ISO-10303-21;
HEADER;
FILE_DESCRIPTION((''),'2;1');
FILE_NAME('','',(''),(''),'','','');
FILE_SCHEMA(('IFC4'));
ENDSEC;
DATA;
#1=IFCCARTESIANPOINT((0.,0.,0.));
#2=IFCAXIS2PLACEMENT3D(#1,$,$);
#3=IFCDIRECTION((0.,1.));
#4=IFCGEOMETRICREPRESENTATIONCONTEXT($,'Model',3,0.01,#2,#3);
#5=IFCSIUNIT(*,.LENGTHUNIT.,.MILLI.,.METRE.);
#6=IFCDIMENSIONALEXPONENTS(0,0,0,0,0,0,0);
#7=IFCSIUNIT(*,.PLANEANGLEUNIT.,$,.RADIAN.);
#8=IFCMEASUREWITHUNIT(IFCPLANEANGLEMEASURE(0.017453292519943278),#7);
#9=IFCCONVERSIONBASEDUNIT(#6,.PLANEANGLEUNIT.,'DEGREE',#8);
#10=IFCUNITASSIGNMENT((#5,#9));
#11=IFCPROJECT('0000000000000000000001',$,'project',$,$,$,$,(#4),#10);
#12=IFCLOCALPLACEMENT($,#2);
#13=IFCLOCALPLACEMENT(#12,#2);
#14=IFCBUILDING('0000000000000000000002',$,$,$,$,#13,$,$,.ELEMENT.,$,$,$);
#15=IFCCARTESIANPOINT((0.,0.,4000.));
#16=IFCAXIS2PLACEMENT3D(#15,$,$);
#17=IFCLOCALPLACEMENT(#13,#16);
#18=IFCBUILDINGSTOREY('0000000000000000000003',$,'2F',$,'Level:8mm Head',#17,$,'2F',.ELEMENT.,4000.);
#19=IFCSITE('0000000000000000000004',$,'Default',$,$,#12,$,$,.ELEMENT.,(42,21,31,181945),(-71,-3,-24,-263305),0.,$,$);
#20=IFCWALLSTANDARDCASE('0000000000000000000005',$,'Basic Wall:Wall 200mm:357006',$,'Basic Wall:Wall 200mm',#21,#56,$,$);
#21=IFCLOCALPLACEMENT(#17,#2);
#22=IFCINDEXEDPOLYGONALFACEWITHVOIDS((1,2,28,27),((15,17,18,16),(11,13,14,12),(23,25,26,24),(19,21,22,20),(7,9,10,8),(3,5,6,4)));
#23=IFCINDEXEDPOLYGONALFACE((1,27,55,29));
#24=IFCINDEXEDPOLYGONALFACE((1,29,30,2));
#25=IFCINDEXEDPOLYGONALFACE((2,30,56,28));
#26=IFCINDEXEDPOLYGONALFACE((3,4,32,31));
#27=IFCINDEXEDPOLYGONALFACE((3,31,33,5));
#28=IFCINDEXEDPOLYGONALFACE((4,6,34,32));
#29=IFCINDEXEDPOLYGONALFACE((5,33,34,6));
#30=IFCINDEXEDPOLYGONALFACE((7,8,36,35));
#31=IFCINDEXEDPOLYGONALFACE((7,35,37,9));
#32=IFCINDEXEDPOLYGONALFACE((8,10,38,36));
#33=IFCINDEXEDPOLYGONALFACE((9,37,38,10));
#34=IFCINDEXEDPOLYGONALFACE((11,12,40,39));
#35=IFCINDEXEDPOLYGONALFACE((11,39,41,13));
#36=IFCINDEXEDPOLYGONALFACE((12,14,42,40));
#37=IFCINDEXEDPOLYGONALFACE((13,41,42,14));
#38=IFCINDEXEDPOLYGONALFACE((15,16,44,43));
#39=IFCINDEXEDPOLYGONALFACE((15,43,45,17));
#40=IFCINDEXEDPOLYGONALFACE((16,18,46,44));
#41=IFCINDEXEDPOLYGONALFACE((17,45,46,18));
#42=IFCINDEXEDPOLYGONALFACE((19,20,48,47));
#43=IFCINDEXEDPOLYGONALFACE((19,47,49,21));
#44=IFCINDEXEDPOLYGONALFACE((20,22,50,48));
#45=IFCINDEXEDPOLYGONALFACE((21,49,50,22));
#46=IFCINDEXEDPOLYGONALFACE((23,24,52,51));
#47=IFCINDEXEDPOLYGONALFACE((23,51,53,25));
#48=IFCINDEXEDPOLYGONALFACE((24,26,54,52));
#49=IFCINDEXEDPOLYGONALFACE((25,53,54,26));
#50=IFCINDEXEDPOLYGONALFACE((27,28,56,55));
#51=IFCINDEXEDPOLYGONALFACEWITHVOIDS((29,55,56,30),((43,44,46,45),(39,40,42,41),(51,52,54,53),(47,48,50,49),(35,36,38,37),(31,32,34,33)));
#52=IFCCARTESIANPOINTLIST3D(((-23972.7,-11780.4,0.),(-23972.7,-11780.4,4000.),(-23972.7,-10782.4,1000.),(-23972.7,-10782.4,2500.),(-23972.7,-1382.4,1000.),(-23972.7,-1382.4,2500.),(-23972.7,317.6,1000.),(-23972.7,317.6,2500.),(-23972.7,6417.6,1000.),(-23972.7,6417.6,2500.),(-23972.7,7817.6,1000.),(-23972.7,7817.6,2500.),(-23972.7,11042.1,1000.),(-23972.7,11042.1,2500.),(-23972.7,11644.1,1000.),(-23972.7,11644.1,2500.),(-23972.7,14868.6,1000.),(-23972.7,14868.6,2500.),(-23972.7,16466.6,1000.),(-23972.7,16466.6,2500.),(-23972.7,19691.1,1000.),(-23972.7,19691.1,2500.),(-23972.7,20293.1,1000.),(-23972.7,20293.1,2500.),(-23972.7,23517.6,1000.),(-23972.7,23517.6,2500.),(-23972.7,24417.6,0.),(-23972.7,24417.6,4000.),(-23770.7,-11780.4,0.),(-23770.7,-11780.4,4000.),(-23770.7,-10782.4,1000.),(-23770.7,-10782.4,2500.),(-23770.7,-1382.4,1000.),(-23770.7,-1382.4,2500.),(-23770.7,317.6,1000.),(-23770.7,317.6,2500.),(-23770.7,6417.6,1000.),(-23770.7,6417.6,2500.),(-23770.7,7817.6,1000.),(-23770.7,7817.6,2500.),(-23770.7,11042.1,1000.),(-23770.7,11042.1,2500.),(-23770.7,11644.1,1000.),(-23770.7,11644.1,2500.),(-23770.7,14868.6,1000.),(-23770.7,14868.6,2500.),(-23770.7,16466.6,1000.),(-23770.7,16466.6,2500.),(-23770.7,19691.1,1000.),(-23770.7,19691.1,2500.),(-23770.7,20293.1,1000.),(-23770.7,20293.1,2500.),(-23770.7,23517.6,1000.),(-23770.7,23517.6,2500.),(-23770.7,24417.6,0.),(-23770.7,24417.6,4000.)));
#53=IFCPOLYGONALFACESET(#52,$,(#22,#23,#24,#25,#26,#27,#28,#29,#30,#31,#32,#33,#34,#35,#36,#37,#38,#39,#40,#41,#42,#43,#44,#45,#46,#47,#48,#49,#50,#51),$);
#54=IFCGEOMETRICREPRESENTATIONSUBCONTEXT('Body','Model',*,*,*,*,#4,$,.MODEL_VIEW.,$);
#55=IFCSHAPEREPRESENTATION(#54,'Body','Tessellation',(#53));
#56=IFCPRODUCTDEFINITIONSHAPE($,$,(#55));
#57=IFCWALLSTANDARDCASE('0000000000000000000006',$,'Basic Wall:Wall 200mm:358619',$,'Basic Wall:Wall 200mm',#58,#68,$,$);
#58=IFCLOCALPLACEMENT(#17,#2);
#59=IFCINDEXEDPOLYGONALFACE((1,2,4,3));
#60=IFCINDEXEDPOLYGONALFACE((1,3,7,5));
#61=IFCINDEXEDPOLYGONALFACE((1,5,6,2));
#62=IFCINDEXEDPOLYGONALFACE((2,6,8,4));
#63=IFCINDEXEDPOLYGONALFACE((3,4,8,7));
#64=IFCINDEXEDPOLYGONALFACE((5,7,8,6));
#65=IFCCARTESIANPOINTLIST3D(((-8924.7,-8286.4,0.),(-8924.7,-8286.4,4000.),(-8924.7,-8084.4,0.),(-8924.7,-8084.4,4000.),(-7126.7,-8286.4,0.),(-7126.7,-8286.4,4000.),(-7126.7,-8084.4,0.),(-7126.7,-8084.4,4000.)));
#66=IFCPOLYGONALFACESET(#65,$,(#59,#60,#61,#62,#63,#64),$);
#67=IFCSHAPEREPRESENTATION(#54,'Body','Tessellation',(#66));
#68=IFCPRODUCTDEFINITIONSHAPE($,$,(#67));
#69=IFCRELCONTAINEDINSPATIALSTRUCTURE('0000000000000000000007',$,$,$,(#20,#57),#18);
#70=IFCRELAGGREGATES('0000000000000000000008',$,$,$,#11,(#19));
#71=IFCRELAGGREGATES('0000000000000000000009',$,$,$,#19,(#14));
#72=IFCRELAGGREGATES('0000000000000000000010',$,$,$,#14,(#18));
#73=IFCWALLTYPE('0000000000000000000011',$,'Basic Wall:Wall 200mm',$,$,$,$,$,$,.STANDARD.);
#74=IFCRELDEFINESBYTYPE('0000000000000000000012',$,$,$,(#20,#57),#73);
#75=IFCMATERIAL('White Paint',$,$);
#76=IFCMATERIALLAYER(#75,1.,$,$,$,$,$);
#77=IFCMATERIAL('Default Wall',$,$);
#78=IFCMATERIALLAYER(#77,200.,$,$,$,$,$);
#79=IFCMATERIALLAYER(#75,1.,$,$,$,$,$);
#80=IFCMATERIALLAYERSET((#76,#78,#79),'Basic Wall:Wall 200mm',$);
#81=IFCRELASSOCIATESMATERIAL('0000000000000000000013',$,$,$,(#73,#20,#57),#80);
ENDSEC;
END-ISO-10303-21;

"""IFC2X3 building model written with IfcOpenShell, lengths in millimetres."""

from ifc_helpers import new_model, entity, si_unit, converted_unit, direction, frame, frame_2d, origin, origin_2d_with_axis, place, context, subcontext, project, spatial, rectangle, extrude, material, layer, layer_set, layer_usage, type_object, element, save


model = new_model("IFC2X3")

# Units and contexts
model_context = context("Model", 3, precision=0.01, world=origin(), true_north=direction((0.0, 1.0)))
body_context = subcontext(model_context, "Body", "Model", "MODEL_VIEW")
ifc_project = project(units=[si_unit("LENGTHUNIT", "METRE", prefix="MILLI"), converted_unit("PLANEANGLEUNIT", "DEGREE", entity("IfcPlaneAngleMeasure", 0.017453292519943278), si_unit("PLANEANGLEUNIT", "RADIAN"), dimensions=[0, 0, 0, 0, 0, 0, 0])], contexts=[model_context])

# Site, building, storey
site_placement = place(None, origin())
site = spatial("IfcSite", under=ifc_project, at=site_placement, Name="Default", CompositionType="ELEMENT", RefLatitude=(42, 21, 31, 181945), RefLongitude=(-71, -3, -24, -263305), RefElevation=0.0)
building_placement = place(site_placement, origin())
building = spatial("IfcBuilding", under=site, at=building_placement, CompositionType="ELEMENT")
storey_placement = place(building_placement, frame((0.0, 0.0, 4000.0)))
storey = spatial("IfcBuildingStorey", under=building, at=storey_placement, Name="2F", ObjectType="Level:8mm Head", LongName="2F", CompositionType="ELEMENT", Elevation=4000.0)

# Wall, openings
ifc_material_1 = material(Name="White Paint")
ifc_layer_1 = layer(ifc_material_1, 1.0)
ifc_material_2 = material(Name="Default Wall")
ifc_layer_2 = layer(ifc_material_2, 200.0)
ifc_layer_3 = layer(ifc_material_1, 1.0)
ifc_layer_set_1 = layer_set([ifc_layer_1, ifc_layer_2, ifc_layer_3], Name="Basic Wall:Wall 200mm")
ifc_layer_usage_1 = layer_usage(ifc_layer_set_1, "AXIS2", "NEGATIVE", 101.0)
wall_type = type_object("IfcWallType", Name="Basic Wall:Wall 200mm", PredefinedType="STANDARD", material=ifc_layer_set_1)
wall_1_placement = place(storey_placement, frame((-23871.7, -11780.4, 0.0), z_axis=(0.0, 0.0, 1.0), x_axis=(0.0, 1.0, 0.0)))
wall_1 = element("IfcWallStandardCase", 1, at=wall_1_placement, inside=storey, type_object=wall_type, material=ifc_layer_usage_1, Name="Basic Wall:Wall 200mm:357006", ObjectType="Basic Wall:Wall 200mm", context=body_context, shape_type="SweptSolid", body=[
    extrude(rectangle(XDim=36198.0, YDim=202.0, at=frame_2d((18099.0, 0.0), x_axis=(-1.0, 0.0))), origin(), (0.0, 0.0, 1.0), 4000.0),
])
opening_1_placement = place(wall_1_placement, origin())
element("IfcOpeningElement", 2, at=opening_1_placement, cuts=wall_1, ObjectType="Opening", context=body_context, shape_type="SweptSolid", body=[
    extrude(rectangle(XDim=1500.0, YDim=3224.5, at=origin_2d_with_axis()), frame((33685.7, 101.0, 1750.0), z_axis=(0.0, -1.0, 0.0), x_axis=(0.0, 0.0, -1.0)), (0.0, 0.0, 1.0), 202.0),
])
opening_2_placement = place(wall_1_placement, origin())
element("IfcOpeningElement", 3, at=opening_2_placement, cuts=wall_1, ObjectType="Opening", context=body_context, shape_type="SweptSolid", body=[
    extrude(rectangle(XDim=1500.0, YDim=3224.5, at=frame_2d((0.0, 0.0), x_axis=(1.0, 0.0))), frame((29859.2, 101.0, 1750.0), z_axis=(0.0, 1.0, 0.0), x_axis=(0.0, 0.0, -1.0)), (0.0, 0.0, -1.0), 202.0),
])
opening_3_placement = place(wall_1_placement, origin())
element("IfcOpeningElement", 4, at=opening_3_placement, cuts=wall_1, ObjectType="Opening", context=body_context, shape_type="SweptSolid", body=[
    extrude(rectangle(XDim=1500.0, YDim=3224.5, at=origin_2d_with_axis()), frame((25036.7, 101.0, 1750.0), z_axis=(0.0, 1.0, 0.0), x_axis=(0.0, 0.0, -1.0)), (0.0, 0.0, -1.0), 202.0),
])
opening_4_placement = place(wall_1_placement, origin())
element("IfcOpeningElement", 5, at=opening_4_placement, cuts=wall_1, ObjectType="Opening", context=body_context, shape_type="SweptSolid", body=[
    extrude(rectangle(XDim=1500.0, YDim=3224.5, at=origin_2d_with_axis()), frame((21210.2, 101.0, 1750.0), z_axis=(0.0, -1.0, 0.0), x_axis=(0.0, 0.0, -1.0)), (0.0, 0.0, 1.0), 202.0),
])
opening_5_placement = place(wall_1_placement, origin())
element("IfcOpeningElement", 6, at=opening_5_placement, cuts=wall_1, ObjectType="Opening", context=body_context, shape_type="SweptSolid", body=[
    extrude(rectangle(XDim=1500.0, YDim=6100.0, at=origin_2d_with_axis()), frame((15148.0, 101.0, 1750.0), z_axis=(0.0, -1.0, 0.0), x_axis=(0.0, 0.0, -1.0)), (0.0, 0.0, 1.0), 202.0),
])
opening_6_placement = place(wall_1_placement, origin())
element("IfcOpeningElement", 7, at=opening_6_placement, cuts=wall_1, ObjectType="Opening", context=body_context, shape_type="SweptSolid", body=[
    extrude(rectangle(XDim=1500.0, YDim=9400.0, at=frame_2d((0.0, 0.0), x_axis=(1.0, 0.0))), frame((5698.0, 101.0, 1750.0), z_axis=(0.0, -1.0, 0.0), x_axis=(0.0, 0.0, -1.0)), (0.0, 0.0, 1.0), 202.0),
])

# Wall
ifc_layer_usage_2 = layer_usage(ifc_layer_set_1, "AXIS2", "NEGATIVE", 101.0)
wall_2_placement = place(storey_placement, frame((-7126.7, -8185.4, 0.0), z_axis=(0.0, 0.0, 1.0), x_axis=(-1.0, 0.0, 0.0)))
element("IfcWallStandardCase", 8, at=wall_2_placement, inside=storey, type_object=wall_type, material=ifc_layer_usage_2, Name="Basic Wall:Wall 200mm:358619", ObjectType="Basic Wall:Wall 200mm", context=body_context, shape_type="SweptSolid", body=[
    extrude(rectangle(XDim=1798.0, YDim=202.0, at=frame_2d((899.0, 0.0), x_axis=(-1.0, 0.0))), origin(), (0.0, 0.0, 1.0), 4000.0),
])

save(model, "model.ifc")
